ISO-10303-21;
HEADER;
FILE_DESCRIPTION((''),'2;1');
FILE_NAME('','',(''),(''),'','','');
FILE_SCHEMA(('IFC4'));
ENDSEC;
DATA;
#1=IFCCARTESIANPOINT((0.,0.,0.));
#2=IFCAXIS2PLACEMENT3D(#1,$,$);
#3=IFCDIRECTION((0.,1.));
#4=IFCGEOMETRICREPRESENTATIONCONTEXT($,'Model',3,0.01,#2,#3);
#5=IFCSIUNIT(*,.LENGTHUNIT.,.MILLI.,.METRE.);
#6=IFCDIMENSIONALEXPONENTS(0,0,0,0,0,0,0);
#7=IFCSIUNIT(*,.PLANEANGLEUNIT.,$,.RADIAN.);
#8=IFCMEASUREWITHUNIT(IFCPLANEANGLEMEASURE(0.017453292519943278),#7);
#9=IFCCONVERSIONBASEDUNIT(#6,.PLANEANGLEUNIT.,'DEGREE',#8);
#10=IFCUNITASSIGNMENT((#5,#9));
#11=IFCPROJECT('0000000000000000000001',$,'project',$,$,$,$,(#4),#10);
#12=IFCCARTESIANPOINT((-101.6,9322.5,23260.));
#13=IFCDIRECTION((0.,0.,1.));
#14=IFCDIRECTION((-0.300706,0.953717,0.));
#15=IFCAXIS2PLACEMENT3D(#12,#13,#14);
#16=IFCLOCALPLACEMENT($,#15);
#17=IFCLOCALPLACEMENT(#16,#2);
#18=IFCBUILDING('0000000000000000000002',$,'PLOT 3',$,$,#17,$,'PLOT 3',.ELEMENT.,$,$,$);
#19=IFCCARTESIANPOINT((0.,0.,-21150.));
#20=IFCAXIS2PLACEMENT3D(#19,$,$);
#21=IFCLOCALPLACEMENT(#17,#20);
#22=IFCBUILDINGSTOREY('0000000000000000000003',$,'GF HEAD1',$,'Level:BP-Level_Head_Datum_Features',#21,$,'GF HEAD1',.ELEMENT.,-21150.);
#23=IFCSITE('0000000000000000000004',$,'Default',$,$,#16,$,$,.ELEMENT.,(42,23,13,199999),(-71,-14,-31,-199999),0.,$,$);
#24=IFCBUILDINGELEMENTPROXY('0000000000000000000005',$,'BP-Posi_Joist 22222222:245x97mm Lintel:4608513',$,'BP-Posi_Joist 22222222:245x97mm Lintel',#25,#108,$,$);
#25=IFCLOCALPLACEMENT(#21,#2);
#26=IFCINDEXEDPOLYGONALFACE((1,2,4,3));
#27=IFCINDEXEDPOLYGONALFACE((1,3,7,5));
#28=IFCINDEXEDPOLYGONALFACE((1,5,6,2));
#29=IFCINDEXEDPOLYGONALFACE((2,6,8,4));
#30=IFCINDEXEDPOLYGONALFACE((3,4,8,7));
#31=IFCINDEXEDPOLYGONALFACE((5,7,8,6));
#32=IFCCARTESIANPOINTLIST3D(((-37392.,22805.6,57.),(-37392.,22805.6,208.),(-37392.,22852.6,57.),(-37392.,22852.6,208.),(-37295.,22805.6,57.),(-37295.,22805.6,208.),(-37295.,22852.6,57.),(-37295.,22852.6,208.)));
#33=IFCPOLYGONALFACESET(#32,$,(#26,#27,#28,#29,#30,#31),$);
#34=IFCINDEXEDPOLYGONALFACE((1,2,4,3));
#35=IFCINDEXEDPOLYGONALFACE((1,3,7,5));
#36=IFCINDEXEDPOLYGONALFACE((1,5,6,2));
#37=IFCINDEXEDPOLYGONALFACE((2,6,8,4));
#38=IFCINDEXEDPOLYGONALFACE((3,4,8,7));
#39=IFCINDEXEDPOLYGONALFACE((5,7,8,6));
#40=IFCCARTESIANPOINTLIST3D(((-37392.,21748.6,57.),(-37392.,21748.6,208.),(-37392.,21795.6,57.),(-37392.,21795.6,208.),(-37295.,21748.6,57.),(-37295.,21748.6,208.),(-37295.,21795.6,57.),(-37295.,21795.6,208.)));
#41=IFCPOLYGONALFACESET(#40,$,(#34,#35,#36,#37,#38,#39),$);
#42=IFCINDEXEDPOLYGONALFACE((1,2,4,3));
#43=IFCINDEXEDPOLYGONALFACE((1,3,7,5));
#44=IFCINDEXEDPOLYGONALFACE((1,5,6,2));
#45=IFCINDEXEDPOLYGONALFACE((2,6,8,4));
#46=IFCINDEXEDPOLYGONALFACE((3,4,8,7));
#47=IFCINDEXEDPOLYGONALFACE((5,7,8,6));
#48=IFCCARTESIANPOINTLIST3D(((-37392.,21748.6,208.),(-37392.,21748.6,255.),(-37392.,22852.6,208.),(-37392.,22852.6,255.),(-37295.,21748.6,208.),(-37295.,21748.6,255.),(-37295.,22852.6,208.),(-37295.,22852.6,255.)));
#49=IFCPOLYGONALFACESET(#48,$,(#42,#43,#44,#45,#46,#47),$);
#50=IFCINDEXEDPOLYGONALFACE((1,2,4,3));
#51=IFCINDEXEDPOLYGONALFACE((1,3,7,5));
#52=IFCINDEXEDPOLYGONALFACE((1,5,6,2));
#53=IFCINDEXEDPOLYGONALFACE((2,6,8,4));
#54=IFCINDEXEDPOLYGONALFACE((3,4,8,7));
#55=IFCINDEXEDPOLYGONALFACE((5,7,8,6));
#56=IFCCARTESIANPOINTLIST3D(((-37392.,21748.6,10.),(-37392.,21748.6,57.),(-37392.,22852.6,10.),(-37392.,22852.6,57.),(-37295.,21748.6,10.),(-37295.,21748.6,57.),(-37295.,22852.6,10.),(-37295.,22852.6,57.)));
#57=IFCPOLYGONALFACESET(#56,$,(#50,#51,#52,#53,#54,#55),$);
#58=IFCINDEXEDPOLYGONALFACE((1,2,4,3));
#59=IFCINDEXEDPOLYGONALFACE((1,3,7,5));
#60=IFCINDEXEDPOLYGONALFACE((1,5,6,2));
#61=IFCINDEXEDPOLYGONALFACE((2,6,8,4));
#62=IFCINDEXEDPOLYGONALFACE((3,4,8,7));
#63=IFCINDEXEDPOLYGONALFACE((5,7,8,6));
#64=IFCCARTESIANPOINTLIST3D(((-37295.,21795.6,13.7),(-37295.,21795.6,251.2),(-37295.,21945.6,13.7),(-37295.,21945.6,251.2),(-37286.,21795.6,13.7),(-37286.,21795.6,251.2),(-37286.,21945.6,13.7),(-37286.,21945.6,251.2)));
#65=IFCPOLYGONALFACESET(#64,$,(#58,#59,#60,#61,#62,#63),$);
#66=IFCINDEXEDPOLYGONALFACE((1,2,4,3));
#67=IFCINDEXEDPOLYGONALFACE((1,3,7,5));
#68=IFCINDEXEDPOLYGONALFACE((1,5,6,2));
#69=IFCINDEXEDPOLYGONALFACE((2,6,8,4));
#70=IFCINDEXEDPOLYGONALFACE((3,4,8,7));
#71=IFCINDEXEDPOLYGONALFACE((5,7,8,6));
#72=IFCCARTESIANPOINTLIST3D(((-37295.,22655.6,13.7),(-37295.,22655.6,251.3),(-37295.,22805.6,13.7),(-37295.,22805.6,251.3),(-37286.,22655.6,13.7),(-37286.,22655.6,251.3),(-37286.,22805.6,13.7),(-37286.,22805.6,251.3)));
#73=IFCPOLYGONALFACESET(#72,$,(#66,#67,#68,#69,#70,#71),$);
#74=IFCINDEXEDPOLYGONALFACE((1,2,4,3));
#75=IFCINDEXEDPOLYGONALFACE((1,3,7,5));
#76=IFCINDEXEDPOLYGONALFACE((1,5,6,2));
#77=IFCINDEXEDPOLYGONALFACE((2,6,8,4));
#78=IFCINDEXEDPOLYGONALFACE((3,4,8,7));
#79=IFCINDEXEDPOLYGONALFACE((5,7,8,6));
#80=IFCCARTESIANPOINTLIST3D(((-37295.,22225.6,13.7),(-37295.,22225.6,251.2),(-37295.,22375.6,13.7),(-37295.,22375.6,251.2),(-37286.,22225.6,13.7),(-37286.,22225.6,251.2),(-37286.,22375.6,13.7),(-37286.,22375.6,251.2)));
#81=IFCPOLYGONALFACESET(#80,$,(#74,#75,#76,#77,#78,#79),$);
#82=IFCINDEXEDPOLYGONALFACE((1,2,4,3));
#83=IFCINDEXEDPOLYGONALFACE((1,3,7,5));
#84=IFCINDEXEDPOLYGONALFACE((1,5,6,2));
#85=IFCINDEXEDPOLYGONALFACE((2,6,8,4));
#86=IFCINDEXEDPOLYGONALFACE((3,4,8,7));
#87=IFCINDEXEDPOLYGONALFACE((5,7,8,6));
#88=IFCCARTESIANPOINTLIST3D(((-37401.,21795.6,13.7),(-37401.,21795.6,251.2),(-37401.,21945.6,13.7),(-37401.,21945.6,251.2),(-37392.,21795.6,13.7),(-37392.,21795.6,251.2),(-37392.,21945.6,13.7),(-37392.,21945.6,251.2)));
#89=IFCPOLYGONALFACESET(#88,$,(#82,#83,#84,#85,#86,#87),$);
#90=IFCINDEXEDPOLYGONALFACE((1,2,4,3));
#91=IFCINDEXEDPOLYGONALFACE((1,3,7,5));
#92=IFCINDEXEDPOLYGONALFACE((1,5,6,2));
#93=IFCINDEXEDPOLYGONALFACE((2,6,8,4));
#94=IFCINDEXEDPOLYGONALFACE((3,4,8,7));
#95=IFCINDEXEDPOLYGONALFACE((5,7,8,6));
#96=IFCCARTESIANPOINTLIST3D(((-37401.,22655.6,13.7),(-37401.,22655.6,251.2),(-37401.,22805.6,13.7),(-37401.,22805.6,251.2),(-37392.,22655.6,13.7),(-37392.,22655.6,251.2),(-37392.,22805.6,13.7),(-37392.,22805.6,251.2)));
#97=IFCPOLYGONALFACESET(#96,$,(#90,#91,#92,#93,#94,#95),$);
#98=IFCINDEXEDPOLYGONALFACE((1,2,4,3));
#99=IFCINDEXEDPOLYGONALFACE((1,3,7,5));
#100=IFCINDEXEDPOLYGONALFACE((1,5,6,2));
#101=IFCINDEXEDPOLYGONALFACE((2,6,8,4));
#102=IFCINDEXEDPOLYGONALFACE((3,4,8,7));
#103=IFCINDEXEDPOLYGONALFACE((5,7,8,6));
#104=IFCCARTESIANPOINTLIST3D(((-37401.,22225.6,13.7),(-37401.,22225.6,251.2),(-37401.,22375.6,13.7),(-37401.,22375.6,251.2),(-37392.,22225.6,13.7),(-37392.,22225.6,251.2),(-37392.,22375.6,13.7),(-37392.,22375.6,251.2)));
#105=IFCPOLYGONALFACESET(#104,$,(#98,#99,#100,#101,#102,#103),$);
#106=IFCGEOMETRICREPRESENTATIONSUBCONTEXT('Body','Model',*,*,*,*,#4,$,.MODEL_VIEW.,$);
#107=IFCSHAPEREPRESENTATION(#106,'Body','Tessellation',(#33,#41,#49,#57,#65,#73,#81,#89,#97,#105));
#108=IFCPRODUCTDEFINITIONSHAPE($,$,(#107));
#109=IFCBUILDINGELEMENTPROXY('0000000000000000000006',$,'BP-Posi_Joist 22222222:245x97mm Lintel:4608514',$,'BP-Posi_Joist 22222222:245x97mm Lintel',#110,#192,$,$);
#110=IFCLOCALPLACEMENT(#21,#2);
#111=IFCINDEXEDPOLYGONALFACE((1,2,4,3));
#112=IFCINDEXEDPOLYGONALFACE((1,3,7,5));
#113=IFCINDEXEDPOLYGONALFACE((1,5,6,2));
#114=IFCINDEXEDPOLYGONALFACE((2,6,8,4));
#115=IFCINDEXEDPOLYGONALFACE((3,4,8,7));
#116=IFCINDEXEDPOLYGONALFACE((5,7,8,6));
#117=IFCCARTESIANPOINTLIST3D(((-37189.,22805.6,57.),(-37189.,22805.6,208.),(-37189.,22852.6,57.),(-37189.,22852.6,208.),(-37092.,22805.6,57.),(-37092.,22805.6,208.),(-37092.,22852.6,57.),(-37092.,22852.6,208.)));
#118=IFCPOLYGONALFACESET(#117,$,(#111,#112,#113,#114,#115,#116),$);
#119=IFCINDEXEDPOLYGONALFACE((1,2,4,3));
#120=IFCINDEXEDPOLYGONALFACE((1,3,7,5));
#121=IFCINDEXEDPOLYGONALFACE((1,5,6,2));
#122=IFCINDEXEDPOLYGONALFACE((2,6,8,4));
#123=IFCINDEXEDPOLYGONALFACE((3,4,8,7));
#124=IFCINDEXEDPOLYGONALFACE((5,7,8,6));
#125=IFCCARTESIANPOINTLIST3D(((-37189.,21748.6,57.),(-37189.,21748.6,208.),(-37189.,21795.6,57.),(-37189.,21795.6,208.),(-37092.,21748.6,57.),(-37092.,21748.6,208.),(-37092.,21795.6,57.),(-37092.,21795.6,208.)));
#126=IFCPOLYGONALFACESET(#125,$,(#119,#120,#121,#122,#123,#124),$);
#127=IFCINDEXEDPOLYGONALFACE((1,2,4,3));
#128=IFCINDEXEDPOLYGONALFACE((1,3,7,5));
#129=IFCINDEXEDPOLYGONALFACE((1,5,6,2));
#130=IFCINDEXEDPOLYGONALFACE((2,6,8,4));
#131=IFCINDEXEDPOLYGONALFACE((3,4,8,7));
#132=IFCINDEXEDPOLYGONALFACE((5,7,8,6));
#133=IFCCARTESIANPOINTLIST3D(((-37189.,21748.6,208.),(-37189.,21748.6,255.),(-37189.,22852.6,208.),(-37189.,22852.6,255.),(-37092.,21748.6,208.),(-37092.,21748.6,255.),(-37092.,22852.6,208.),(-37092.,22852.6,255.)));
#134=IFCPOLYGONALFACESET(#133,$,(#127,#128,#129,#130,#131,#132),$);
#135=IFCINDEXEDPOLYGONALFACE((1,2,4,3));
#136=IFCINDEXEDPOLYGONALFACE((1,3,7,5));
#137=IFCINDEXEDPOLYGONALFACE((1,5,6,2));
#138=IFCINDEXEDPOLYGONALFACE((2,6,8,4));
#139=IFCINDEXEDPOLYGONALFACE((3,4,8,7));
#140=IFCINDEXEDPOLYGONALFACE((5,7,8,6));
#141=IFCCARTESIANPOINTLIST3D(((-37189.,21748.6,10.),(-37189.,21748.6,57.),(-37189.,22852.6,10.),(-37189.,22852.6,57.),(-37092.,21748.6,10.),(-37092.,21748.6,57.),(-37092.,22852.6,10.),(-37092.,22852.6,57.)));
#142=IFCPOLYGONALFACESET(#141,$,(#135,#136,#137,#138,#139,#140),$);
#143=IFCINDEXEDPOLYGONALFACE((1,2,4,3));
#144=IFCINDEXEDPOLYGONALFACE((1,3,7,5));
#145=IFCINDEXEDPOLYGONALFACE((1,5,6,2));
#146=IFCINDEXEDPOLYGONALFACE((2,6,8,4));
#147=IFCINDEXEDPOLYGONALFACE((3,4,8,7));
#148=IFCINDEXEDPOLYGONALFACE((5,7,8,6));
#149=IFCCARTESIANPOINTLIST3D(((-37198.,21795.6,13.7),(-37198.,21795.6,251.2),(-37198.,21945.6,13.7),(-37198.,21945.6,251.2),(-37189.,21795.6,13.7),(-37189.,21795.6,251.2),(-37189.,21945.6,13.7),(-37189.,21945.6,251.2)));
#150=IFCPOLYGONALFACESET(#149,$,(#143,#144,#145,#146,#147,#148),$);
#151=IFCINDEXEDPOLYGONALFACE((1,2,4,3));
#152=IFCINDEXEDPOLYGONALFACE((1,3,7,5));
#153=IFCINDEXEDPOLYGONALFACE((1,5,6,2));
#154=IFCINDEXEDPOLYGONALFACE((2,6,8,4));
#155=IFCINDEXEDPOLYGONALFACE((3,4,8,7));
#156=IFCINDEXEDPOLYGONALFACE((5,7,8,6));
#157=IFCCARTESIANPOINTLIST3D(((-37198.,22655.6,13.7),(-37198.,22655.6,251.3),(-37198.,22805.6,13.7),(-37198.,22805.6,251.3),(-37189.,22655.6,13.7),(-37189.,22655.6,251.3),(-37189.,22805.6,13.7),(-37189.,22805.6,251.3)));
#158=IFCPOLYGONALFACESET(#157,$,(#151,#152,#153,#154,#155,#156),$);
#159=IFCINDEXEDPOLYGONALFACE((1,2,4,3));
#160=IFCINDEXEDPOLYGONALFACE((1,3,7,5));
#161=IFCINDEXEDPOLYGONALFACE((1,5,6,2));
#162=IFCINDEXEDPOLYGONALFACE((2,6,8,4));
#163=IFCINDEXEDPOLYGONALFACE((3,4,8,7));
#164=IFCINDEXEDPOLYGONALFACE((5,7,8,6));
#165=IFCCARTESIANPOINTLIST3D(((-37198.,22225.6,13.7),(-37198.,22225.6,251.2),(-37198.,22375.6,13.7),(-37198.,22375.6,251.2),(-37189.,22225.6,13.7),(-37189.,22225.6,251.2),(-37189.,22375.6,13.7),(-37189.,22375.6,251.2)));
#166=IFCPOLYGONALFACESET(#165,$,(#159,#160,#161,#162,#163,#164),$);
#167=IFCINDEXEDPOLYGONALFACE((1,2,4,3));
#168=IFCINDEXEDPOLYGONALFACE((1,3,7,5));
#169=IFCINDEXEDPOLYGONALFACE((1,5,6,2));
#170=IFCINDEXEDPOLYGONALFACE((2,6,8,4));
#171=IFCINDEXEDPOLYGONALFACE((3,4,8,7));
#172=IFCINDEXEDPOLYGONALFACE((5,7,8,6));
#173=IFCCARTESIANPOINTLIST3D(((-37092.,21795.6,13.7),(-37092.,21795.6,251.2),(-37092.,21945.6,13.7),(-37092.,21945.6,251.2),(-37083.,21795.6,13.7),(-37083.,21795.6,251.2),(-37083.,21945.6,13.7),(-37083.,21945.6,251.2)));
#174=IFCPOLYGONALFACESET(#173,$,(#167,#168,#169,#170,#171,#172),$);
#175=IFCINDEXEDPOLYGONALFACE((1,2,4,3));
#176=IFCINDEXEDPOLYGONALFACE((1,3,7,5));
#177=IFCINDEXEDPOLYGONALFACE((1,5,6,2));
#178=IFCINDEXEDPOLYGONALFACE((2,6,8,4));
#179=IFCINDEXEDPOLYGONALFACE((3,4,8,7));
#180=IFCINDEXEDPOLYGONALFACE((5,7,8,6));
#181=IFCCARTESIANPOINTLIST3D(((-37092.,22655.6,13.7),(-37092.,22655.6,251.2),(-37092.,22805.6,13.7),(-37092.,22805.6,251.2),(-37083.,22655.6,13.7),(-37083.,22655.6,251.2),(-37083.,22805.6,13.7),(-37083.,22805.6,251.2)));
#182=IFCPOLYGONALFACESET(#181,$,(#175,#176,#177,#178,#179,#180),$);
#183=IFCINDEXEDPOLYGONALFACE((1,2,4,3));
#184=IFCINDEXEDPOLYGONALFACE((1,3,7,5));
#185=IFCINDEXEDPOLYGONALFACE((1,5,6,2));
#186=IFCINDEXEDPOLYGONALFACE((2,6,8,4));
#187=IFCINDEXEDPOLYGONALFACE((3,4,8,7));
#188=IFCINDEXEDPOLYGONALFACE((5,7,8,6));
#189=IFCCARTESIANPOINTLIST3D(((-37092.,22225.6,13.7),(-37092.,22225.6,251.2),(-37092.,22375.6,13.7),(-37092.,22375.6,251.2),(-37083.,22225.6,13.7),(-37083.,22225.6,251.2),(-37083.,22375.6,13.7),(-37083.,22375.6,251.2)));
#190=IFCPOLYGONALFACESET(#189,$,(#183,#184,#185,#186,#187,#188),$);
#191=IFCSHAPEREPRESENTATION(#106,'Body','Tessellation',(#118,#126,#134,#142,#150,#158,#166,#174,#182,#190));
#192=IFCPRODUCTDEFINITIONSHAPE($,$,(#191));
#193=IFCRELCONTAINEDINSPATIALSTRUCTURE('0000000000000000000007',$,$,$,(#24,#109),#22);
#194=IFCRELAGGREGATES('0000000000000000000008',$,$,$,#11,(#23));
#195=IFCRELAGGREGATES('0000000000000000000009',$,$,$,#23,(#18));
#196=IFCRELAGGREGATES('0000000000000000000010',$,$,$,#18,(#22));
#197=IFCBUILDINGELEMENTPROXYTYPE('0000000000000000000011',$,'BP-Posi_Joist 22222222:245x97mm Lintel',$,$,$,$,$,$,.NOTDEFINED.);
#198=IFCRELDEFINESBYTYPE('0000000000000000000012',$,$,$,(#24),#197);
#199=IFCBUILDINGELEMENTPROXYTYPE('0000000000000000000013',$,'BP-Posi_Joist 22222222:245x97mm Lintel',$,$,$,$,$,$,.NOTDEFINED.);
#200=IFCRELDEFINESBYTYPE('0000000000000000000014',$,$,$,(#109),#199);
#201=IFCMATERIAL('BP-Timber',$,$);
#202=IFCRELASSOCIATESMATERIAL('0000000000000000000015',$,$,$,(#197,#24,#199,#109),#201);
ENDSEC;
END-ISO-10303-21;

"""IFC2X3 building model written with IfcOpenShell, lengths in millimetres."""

from ifc_helpers import new_model, entity, si_unit, converted_unit, direction, frame, frame_2d, origin, origin_2d_with_axis, place, context, subcontext, project, spatial, rectangle, extrude, source, transform, mapped, material, type_object, type_shapes, element, save


model = new_model("IFC2X3")

# Units and contexts
model_context = context("Model", 3, precision=0.01, world=origin(), true_north=direction((0.0, 1.0)))
body_context = subcontext(model_context, "Body", "Model", "MODEL_VIEW")
ifc_project = project(units=[si_unit("LENGTHUNIT", "METRE", prefix="MILLI"), converted_unit("PLANEANGLEUNIT", "DEGREE", entity("IfcPlaneAngleMeasure", 0.017453292519943278), si_unit("PLANEANGLEUNIT", "RADIAN"), dimensions=[0, 0, 0, 0, 0, 0, 0])], contexts=[model_context])

# Site, building, storey
site_placement = place(None, frame((-101.6, 9322.5, 23260.0), z_axis=(0.0, 0.0, 1.0), x_axis=(-0.300706, 0.953717, 0.0)))
site = spatial("IfcSite", under=ifc_project, at=site_placement, Name="Default", CompositionType="ELEMENT", RefLatitude=(42, 23, 13, 199999), RefLongitude=(-71, -14, -31, -199999), RefElevation=0.0)
building_placement = place(site_placement, origin())
building = spatial("IfcBuilding", under=site, at=building_placement, Name="PLOT 3", LongName="PLOT 3", CompositionType="ELEMENT")
storey_placement = place(building_placement, frame((0.0, 0.0, -21150.0)))
storey = spatial("IfcBuildingStorey", under=building, at=storey_placement, Name="GF HEAD1", ObjectType="Level:BP-Level_Head_Datum_Features", LongName="GF HEAD1", CompositionType="ELEMENT", Elevation=-21150.0)

# Shared definitions
ifc_material_1 = material(Name="BP-Timber")

# Building element proxies
building_element_proxy_type_1 = type_object("IfcBuildingElementProxyType", Name="BP-Posi_Joist 22222222:245x97mm Lintel", PredefinedType="NOTDEFINED", material=ifc_material_1)
shared_shape_1 = source(origin(), body_context, "Body", "SweptSolid", [
    extrude(rectangle(XDim=47.0, YDim=97.0, at=origin_2d_with_axis()), frame((320.4, 0.0, -198.0), z_axis=(0.0, 0.0, 1.0), x_axis=(-1.0, 0.0, 0.0)), (0.0, 0.0, 1.0), 151.0),
    extrude(rectangle(XDim=47.0, YDim=97.0, at=origin_2d_with_axis()), frame((1377.4, 0.0, -198.0), z_axis=(0.0, 0.0, 1.0), x_axis=(-1.0, 0.0, 0.0)), (0.0, 0.0, 1.0), 151.0),
    extrude(rectangle(XDim=97.0, YDim=1104.0, at=origin_2d_with_axis()), frame((848.9, 0.0, -47.0), z_axis=(0.0, 0.0, 1.0), x_axis=(0.0, -1.0, 0.0)), (0.0, 0.0, 1.0), 47.0),
    extrude(rectangle(XDim=97.0, YDim=1104.0, at=origin_2d_with_axis()), frame((848.9, 0.0, -245.0), z_axis=(0.0, 0.0, 1.0), x_axis=(0.0, -1.0, 0.0)), (0.0, 0.0, 1.0), 47.0),
    extrude(rectangle(XDim=9.0, YDim=150.0, at=frame_2d((0.0, 0.0), x_axis=(1.0, 0.0))), frame((1278.9, 53.0, -241.3), z_axis=(0.0, 0.0, 1.0), x_axis=(0.0, -1.0, 0.0)), (0.0, 0.0, 1.0), 237.5),
    extrude(rectangle(XDim=9.0, YDim=150.0, at=frame_2d((0.0, 0.0), x_axis=(1.0, 0.0))), frame((418.9, 53.0, -241.3), z_axis=(0.0, 0.0, 1.0), x_axis=(0.0, 1.0, 0.0)), (0.0, 0.0, 1.0), 237.5),
    extrude(rectangle(XDim=9.0, YDim=150.0, at=frame_2d((0.0, 0.0), x_axis=(1.0, 0.0))), frame((848.9, 53.0, -241.3), z_axis=(0.0, 0.0, 1.0), x_axis=(0.0, -1.0, 0.0)), (0.0, 0.0, 1.0), 237.5),
    extrude(rectangle(XDim=9.0, YDim=150.0, at=frame_2d((0.0, 0.0), x_axis=(1.0, 0.0))), frame((1278.9, -53.0, -241.3), z_axis=(0.0, 0.0, 1.0), x_axis=(0.0, -1.0, 0.0)), (0.0, 0.0, 1.0), 237.5),
    extrude(rectangle(XDim=9.0, YDim=150.0, at=frame_2d((0.0, 0.0), x_axis=(1.0, 0.0))), frame((418.9, -53.0, -241.3), z_axis=(0.0, 0.0, 1.0), x_axis=(0.0, 1.0, 0.0)), (0.0, 0.0, 1.0), 237.5),
    extrude(rectangle(XDim=9.0, YDim=150.0, at=origin_2d_with_axis()), frame((848.9, -53.0, -241.3), z_axis=(0.0, 0.0, 1.0), x_axis=(0.0, -1.0, 0.0)), (0.0, 0.0, 1.0), 237.5),
])
type_shapes(building_element_proxy_type_1, [shared_shape_1])
proxy_1_placement = place(storey_placement, frame((-37343.5, 23149.5, 255.0), z_axis=(0.0, 0.0, 1.0), x_axis=(0.0, -1.0, 0.0)))
element("IfcBuildingElementProxy", 1, at=proxy_1_placement, inside=storey, type_object=building_element_proxy_type_1, material=ifc_material_1, Name="BP-Posi_Joist 22222222:245x97mm Lintel:4608513", ObjectType="BP-Posi_Joist 22222222:245x97mm Lintel", context=body_context, shape_type="MappedRepresentation", body=[
    mapped(shared_shape_1, transform((0.0, 0.0, 0.0), scale=1.0)),
])
building_element_proxy_type_2 = type_object("IfcBuildingElementProxyType", Name="BP-Posi_Joist 22222222:245x97mm Lintel", PredefinedType="NOTDEFINED", material=ifc_material_1)
shared_shape_2 = source(origin(), body_context, "Body", "SweptSolid", [
    extrude(rectangle(XDim=97.0, YDim=47.0, at=origin_2d_with_axis()), frame((320.4, 0.0, -198.0), z_axis=(0.0, 0.0, 1.0), x_axis=(0.0, 1.0, 0.0)), (0.0, 0.0, 1.0), 151.0),
    extrude(rectangle(XDim=97.0, YDim=47.0, at=origin_2d_with_axis()), frame((1377.4, 0.0, -198.0), z_axis=(0.0, 0.0, 1.0), x_axis=(0.0, 1.0, 0.0)), (0.0, 0.0, 1.0), 151.0),
    extrude(rectangle(XDim=1104.0, YDim=97.0, at=frame_2d((0.0, 0.0), x_axis=(1.0, 0.0))), frame((848.9, 0.0, -47.0)), (0.0, 0.0, 1.0), 47.0),
    extrude(rectangle(XDim=1104.0, YDim=97.0, at=frame_2d((0.0, 0.0), x_axis=(1.0, 0.0))), frame((848.9, 0.0, -245.0)), (0.0, 0.0, 1.0), 47.0),
    extrude(rectangle(XDim=150.0, YDim=9.0, at=frame_2d((0.0, 0.0), x_axis=(1.0, 0.0))), frame((1278.9, -53.0, -241.3)), (0.0, 0.0, 1.0), 237.5),
    extrude(rectangle(XDim=150.0, YDim=9.0, at=frame_2d((0.0, 0.0), x_axis=(1.0, 0.0))), frame((418.9, -53.0, -241.3), z_axis=(0.0, 0.0, 1.0), x_axis=(-1.0, 0.0, 0.0)), (0.0, 0.0, 1.0), 237.5),
    extrude(rectangle(XDim=150.0, YDim=9.0, at=frame_2d((0.0, 0.0), x_axis=(1.0, 0.0))), frame((848.9, -53.0, -241.3)), (0.0, 0.0, 1.0), 237.5),
    extrude(rectangle(XDim=150.0, YDim=9.0, at=frame_2d((0.0, 0.0), x_axis=(1.0, 0.0))), frame((1278.9, 53.0, -241.3)), (0.0, 0.0, 1.0), 237.5),
    extrude(rectangle(XDim=150.0, YDim=9.0, at=frame_2d((0.0, 0.0), x_axis=(1.0, 0.0))), frame((418.9, 53.0, -241.3), z_axis=(0.0, 0.0, 1.0), x_axis=(-1.0, 0.0, 0.0)), (0.0, 0.0, 1.0), 237.5),
    extrude(rectangle(XDim=150.0, YDim=9.0, at=origin_2d_with_axis()), frame((848.9, 53.0, -241.3)), (0.0, 0.0, 1.0), 237.5),
])
type_shapes(building_element_proxy_type_2, [shared_shape_2])
proxy_2_placement = place(storey_placement, frame((-37140.5, 23149.5, 255.0), z_axis=(0.0, 0.0, 1.0), x_axis=(0.0, -1.0, 0.0)))
element("IfcBuildingElementProxy", 2, at=proxy_2_placement, inside=storey, type_object=building_element_proxy_type_2, material=ifc_material_1, Name="BP-Posi_Joist 22222222:245x97mm Lintel:4608514", ObjectType="BP-Posi_Joist 22222222:245x97mm Lintel", context=body_context, shape_type="MappedRepresentation", body=[
    mapped(shared_shape_2, transform((0.0, 0.0, 0.0), scale=1.0)),
])

save(model, "model.ifc")
